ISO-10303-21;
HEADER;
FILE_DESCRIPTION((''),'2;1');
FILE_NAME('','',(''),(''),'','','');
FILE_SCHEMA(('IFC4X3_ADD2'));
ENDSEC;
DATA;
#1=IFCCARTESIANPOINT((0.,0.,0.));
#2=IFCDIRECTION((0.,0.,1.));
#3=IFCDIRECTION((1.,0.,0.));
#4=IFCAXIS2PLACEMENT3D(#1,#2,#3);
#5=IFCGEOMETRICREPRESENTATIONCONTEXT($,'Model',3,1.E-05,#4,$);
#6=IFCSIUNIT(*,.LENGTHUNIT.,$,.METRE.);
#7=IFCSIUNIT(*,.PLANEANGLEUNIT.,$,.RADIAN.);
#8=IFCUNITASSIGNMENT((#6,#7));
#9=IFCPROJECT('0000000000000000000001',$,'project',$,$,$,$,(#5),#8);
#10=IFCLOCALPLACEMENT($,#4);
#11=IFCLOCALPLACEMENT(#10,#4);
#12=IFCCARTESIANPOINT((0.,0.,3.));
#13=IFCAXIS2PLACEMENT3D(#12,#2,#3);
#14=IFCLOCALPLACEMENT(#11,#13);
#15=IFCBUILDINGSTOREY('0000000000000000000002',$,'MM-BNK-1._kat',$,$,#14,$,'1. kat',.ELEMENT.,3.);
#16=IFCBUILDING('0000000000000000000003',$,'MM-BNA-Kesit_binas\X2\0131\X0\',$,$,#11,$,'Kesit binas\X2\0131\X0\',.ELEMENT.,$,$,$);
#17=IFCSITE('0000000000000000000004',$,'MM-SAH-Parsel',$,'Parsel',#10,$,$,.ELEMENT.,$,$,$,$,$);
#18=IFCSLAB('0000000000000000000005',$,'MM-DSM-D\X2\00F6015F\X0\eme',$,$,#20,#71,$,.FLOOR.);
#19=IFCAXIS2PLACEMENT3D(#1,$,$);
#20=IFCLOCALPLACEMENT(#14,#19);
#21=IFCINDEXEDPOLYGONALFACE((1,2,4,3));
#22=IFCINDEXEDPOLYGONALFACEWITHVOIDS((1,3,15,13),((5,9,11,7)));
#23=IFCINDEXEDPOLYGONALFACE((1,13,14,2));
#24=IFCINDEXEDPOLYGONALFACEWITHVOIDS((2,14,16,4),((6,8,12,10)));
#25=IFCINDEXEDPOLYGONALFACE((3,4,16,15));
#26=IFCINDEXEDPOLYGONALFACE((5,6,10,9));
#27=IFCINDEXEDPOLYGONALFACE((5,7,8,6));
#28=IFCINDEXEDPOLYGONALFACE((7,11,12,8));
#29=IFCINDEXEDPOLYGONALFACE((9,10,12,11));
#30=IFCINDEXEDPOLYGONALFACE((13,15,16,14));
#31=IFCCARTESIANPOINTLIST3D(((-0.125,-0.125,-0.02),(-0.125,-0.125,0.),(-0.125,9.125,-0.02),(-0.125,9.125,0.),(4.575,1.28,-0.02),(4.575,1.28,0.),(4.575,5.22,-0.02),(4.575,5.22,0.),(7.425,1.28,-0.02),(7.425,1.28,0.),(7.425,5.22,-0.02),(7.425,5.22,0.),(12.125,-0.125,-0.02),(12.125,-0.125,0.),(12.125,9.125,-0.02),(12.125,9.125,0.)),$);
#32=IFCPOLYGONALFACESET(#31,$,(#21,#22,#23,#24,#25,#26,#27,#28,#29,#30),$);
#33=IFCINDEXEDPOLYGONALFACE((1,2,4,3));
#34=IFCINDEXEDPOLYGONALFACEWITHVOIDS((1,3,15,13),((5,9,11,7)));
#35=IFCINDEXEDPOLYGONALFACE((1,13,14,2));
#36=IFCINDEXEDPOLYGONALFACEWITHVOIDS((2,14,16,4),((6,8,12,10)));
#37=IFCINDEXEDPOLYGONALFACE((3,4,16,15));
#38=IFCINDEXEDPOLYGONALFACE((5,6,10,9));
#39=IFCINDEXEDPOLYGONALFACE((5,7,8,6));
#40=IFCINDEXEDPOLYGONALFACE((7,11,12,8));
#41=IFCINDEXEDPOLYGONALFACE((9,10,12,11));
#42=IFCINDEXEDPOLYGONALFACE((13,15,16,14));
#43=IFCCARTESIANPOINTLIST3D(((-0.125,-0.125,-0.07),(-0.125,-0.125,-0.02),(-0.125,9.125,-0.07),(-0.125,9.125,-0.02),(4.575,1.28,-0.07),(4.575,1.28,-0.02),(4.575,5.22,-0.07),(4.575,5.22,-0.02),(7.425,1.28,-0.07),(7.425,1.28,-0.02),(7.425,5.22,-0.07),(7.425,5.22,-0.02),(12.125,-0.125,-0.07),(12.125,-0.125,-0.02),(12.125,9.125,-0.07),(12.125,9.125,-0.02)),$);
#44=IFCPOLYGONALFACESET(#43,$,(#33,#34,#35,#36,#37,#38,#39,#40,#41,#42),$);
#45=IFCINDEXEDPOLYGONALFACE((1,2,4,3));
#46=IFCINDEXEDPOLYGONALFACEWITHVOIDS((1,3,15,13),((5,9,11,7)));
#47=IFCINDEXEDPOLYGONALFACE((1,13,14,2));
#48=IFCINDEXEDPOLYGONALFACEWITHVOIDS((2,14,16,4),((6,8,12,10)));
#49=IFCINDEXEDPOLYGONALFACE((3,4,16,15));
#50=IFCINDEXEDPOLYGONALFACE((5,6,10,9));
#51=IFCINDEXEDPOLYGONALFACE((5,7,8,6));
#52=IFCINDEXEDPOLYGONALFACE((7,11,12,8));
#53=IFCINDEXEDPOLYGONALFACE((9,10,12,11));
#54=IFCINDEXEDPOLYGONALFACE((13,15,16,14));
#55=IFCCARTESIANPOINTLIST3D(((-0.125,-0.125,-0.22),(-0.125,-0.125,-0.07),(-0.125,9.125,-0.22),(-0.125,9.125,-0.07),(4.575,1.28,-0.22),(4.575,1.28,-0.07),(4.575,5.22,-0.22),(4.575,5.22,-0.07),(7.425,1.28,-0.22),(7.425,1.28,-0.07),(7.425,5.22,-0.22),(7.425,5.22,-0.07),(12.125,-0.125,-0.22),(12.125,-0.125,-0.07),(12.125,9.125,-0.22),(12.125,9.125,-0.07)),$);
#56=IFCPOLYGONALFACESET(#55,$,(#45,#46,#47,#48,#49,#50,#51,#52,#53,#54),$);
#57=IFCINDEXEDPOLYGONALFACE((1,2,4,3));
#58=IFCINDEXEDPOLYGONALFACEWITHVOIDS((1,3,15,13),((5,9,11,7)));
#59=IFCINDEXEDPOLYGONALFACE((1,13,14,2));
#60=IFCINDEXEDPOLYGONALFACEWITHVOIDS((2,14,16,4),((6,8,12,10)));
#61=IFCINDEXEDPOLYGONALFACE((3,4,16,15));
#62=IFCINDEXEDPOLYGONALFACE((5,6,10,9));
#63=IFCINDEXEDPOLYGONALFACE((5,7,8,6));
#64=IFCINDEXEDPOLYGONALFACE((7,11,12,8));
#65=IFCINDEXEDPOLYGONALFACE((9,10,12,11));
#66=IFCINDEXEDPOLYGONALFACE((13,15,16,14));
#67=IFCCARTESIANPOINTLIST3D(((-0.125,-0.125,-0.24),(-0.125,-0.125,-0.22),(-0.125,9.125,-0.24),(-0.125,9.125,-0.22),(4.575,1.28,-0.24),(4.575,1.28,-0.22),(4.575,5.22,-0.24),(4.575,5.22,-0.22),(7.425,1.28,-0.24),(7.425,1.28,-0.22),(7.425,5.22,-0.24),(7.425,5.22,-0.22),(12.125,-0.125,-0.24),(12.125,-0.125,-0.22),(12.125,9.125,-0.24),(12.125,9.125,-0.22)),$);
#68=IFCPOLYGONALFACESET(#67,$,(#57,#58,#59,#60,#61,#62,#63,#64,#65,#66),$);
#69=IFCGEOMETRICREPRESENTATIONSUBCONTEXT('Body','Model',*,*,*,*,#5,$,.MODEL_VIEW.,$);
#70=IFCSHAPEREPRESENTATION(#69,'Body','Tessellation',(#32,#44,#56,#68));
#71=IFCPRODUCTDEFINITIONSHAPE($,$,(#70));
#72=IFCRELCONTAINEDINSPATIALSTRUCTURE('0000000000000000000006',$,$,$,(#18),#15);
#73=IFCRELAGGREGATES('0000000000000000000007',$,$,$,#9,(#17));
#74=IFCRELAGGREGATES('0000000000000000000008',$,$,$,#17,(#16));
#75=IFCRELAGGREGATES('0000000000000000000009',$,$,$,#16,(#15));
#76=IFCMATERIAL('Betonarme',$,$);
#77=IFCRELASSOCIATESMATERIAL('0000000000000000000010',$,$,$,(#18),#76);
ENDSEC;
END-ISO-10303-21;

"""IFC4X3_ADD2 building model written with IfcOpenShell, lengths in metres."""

from ifc_helpers import new_model, si_unit, frame, origin_with_axes, place, context, subcontext, project, spatial, polyline, outline, extrude, material, element, save


model = new_model("IFC4X3_ADD2")

# Units and contexts
model_context = context("Model", 3, precision=1e-05, world=origin_with_axes())
body_context = subcontext(model_context, "Body", "Model", "MODEL_VIEW")
ifc_project = project(units=[si_unit("LENGTHUNIT", "METRE"), si_unit("PLANEANGLEUNIT", "RADIAN")], contexts=[model_context])

# Site, building, storey
site_placement = place(None, origin_with_axes())
site = spatial("IfcSite", under=ifc_project, at=site_placement, Name="MM-SAH-Parsel", ObjectType="Parsel", CompositionType="ELEMENT")
building_placement = place(site_placement, origin_with_axes())
building = spatial("IfcBuilding", under=site, at=building_placement, Name="MM-BNA-Kesit_binası", LongName="Kesit binası", CompositionType="ELEMENT")
storey_placement = place(building_placement, frame((0.0, 0.0, 3.0), z_axis=(0.0, 0.0, 1.0), x_axis=(1.0, 0.0, 0.0)))
storey = spatial("IfcBuildingStorey", under=building, at=storey_placement, Name="MM-BNK-1._kat", LongName="1. kat", CompositionType="ELEMENT", Elevation=3.0)

# Shared definitions
ifc_material_1 = material(Name="Betonarme")

# Slab, opening
slab_placement = place(storey_placement, origin_with_axes())
slab = element("IfcSlab", 1, at=slab_placement, inside=storey, material=ifc_material_1, Name="MM-DSM-Döşeme", PredefinedType="FLOOR", context=body_context, shape_type="SweptSolid", body=[
    extrude(outline(polyline([(-0.125, -0.125), (12.125, -0.125), (12.125, 9.125), (-0.125, 9.125), (-0.125, -0.125)])), frame((0.0, 0.0, -0.02)), (0.0, 0.0, 1.0), 0.02),
    extrude(outline(polyline([(-0.125, -0.125), (12.125, -0.125), (12.125, 9.125), (-0.125, 9.125), (-0.125, -0.125)])), frame((0.0, 0.0, -0.07)), (0.0, 0.0, 1.0), 0.05),
    extrude(outline(polyline([(-0.125, -0.125), (12.125, -0.125), (12.125, 9.125), (-0.125, 9.125), (-0.125, -0.125)])), frame((0.0, 0.0, -0.22)), (0.0, 0.0, 1.0), 0.15),
    extrude(outline(polyline([(-0.125, -0.125), (12.125, -0.125), (12.125, 9.125), (-0.125, 9.125), (-0.125, -0.125)])), frame((0.0, 0.0, -0.24)), (0.0, 0.0, 1.0), 0.02),
])
opening_1_placement = place(storey_placement, origin_with_axes())
element("IfcOpeningElement", 2, at=opening_1_placement, cuts=slab, PredefinedType="OPENING", context=body_context, shape_type="SweptSolid", body=[
    extrude(outline(polyline([(4.575, 1.28), (4.575, 5.22), (7.425, 5.22), (7.425, 1.28), (4.575, 1.28)])), frame((0.0, 0.0, -0.24)), (0.0, 0.0, 1.0), 0.24),
])

save(model, "model.ifc")
